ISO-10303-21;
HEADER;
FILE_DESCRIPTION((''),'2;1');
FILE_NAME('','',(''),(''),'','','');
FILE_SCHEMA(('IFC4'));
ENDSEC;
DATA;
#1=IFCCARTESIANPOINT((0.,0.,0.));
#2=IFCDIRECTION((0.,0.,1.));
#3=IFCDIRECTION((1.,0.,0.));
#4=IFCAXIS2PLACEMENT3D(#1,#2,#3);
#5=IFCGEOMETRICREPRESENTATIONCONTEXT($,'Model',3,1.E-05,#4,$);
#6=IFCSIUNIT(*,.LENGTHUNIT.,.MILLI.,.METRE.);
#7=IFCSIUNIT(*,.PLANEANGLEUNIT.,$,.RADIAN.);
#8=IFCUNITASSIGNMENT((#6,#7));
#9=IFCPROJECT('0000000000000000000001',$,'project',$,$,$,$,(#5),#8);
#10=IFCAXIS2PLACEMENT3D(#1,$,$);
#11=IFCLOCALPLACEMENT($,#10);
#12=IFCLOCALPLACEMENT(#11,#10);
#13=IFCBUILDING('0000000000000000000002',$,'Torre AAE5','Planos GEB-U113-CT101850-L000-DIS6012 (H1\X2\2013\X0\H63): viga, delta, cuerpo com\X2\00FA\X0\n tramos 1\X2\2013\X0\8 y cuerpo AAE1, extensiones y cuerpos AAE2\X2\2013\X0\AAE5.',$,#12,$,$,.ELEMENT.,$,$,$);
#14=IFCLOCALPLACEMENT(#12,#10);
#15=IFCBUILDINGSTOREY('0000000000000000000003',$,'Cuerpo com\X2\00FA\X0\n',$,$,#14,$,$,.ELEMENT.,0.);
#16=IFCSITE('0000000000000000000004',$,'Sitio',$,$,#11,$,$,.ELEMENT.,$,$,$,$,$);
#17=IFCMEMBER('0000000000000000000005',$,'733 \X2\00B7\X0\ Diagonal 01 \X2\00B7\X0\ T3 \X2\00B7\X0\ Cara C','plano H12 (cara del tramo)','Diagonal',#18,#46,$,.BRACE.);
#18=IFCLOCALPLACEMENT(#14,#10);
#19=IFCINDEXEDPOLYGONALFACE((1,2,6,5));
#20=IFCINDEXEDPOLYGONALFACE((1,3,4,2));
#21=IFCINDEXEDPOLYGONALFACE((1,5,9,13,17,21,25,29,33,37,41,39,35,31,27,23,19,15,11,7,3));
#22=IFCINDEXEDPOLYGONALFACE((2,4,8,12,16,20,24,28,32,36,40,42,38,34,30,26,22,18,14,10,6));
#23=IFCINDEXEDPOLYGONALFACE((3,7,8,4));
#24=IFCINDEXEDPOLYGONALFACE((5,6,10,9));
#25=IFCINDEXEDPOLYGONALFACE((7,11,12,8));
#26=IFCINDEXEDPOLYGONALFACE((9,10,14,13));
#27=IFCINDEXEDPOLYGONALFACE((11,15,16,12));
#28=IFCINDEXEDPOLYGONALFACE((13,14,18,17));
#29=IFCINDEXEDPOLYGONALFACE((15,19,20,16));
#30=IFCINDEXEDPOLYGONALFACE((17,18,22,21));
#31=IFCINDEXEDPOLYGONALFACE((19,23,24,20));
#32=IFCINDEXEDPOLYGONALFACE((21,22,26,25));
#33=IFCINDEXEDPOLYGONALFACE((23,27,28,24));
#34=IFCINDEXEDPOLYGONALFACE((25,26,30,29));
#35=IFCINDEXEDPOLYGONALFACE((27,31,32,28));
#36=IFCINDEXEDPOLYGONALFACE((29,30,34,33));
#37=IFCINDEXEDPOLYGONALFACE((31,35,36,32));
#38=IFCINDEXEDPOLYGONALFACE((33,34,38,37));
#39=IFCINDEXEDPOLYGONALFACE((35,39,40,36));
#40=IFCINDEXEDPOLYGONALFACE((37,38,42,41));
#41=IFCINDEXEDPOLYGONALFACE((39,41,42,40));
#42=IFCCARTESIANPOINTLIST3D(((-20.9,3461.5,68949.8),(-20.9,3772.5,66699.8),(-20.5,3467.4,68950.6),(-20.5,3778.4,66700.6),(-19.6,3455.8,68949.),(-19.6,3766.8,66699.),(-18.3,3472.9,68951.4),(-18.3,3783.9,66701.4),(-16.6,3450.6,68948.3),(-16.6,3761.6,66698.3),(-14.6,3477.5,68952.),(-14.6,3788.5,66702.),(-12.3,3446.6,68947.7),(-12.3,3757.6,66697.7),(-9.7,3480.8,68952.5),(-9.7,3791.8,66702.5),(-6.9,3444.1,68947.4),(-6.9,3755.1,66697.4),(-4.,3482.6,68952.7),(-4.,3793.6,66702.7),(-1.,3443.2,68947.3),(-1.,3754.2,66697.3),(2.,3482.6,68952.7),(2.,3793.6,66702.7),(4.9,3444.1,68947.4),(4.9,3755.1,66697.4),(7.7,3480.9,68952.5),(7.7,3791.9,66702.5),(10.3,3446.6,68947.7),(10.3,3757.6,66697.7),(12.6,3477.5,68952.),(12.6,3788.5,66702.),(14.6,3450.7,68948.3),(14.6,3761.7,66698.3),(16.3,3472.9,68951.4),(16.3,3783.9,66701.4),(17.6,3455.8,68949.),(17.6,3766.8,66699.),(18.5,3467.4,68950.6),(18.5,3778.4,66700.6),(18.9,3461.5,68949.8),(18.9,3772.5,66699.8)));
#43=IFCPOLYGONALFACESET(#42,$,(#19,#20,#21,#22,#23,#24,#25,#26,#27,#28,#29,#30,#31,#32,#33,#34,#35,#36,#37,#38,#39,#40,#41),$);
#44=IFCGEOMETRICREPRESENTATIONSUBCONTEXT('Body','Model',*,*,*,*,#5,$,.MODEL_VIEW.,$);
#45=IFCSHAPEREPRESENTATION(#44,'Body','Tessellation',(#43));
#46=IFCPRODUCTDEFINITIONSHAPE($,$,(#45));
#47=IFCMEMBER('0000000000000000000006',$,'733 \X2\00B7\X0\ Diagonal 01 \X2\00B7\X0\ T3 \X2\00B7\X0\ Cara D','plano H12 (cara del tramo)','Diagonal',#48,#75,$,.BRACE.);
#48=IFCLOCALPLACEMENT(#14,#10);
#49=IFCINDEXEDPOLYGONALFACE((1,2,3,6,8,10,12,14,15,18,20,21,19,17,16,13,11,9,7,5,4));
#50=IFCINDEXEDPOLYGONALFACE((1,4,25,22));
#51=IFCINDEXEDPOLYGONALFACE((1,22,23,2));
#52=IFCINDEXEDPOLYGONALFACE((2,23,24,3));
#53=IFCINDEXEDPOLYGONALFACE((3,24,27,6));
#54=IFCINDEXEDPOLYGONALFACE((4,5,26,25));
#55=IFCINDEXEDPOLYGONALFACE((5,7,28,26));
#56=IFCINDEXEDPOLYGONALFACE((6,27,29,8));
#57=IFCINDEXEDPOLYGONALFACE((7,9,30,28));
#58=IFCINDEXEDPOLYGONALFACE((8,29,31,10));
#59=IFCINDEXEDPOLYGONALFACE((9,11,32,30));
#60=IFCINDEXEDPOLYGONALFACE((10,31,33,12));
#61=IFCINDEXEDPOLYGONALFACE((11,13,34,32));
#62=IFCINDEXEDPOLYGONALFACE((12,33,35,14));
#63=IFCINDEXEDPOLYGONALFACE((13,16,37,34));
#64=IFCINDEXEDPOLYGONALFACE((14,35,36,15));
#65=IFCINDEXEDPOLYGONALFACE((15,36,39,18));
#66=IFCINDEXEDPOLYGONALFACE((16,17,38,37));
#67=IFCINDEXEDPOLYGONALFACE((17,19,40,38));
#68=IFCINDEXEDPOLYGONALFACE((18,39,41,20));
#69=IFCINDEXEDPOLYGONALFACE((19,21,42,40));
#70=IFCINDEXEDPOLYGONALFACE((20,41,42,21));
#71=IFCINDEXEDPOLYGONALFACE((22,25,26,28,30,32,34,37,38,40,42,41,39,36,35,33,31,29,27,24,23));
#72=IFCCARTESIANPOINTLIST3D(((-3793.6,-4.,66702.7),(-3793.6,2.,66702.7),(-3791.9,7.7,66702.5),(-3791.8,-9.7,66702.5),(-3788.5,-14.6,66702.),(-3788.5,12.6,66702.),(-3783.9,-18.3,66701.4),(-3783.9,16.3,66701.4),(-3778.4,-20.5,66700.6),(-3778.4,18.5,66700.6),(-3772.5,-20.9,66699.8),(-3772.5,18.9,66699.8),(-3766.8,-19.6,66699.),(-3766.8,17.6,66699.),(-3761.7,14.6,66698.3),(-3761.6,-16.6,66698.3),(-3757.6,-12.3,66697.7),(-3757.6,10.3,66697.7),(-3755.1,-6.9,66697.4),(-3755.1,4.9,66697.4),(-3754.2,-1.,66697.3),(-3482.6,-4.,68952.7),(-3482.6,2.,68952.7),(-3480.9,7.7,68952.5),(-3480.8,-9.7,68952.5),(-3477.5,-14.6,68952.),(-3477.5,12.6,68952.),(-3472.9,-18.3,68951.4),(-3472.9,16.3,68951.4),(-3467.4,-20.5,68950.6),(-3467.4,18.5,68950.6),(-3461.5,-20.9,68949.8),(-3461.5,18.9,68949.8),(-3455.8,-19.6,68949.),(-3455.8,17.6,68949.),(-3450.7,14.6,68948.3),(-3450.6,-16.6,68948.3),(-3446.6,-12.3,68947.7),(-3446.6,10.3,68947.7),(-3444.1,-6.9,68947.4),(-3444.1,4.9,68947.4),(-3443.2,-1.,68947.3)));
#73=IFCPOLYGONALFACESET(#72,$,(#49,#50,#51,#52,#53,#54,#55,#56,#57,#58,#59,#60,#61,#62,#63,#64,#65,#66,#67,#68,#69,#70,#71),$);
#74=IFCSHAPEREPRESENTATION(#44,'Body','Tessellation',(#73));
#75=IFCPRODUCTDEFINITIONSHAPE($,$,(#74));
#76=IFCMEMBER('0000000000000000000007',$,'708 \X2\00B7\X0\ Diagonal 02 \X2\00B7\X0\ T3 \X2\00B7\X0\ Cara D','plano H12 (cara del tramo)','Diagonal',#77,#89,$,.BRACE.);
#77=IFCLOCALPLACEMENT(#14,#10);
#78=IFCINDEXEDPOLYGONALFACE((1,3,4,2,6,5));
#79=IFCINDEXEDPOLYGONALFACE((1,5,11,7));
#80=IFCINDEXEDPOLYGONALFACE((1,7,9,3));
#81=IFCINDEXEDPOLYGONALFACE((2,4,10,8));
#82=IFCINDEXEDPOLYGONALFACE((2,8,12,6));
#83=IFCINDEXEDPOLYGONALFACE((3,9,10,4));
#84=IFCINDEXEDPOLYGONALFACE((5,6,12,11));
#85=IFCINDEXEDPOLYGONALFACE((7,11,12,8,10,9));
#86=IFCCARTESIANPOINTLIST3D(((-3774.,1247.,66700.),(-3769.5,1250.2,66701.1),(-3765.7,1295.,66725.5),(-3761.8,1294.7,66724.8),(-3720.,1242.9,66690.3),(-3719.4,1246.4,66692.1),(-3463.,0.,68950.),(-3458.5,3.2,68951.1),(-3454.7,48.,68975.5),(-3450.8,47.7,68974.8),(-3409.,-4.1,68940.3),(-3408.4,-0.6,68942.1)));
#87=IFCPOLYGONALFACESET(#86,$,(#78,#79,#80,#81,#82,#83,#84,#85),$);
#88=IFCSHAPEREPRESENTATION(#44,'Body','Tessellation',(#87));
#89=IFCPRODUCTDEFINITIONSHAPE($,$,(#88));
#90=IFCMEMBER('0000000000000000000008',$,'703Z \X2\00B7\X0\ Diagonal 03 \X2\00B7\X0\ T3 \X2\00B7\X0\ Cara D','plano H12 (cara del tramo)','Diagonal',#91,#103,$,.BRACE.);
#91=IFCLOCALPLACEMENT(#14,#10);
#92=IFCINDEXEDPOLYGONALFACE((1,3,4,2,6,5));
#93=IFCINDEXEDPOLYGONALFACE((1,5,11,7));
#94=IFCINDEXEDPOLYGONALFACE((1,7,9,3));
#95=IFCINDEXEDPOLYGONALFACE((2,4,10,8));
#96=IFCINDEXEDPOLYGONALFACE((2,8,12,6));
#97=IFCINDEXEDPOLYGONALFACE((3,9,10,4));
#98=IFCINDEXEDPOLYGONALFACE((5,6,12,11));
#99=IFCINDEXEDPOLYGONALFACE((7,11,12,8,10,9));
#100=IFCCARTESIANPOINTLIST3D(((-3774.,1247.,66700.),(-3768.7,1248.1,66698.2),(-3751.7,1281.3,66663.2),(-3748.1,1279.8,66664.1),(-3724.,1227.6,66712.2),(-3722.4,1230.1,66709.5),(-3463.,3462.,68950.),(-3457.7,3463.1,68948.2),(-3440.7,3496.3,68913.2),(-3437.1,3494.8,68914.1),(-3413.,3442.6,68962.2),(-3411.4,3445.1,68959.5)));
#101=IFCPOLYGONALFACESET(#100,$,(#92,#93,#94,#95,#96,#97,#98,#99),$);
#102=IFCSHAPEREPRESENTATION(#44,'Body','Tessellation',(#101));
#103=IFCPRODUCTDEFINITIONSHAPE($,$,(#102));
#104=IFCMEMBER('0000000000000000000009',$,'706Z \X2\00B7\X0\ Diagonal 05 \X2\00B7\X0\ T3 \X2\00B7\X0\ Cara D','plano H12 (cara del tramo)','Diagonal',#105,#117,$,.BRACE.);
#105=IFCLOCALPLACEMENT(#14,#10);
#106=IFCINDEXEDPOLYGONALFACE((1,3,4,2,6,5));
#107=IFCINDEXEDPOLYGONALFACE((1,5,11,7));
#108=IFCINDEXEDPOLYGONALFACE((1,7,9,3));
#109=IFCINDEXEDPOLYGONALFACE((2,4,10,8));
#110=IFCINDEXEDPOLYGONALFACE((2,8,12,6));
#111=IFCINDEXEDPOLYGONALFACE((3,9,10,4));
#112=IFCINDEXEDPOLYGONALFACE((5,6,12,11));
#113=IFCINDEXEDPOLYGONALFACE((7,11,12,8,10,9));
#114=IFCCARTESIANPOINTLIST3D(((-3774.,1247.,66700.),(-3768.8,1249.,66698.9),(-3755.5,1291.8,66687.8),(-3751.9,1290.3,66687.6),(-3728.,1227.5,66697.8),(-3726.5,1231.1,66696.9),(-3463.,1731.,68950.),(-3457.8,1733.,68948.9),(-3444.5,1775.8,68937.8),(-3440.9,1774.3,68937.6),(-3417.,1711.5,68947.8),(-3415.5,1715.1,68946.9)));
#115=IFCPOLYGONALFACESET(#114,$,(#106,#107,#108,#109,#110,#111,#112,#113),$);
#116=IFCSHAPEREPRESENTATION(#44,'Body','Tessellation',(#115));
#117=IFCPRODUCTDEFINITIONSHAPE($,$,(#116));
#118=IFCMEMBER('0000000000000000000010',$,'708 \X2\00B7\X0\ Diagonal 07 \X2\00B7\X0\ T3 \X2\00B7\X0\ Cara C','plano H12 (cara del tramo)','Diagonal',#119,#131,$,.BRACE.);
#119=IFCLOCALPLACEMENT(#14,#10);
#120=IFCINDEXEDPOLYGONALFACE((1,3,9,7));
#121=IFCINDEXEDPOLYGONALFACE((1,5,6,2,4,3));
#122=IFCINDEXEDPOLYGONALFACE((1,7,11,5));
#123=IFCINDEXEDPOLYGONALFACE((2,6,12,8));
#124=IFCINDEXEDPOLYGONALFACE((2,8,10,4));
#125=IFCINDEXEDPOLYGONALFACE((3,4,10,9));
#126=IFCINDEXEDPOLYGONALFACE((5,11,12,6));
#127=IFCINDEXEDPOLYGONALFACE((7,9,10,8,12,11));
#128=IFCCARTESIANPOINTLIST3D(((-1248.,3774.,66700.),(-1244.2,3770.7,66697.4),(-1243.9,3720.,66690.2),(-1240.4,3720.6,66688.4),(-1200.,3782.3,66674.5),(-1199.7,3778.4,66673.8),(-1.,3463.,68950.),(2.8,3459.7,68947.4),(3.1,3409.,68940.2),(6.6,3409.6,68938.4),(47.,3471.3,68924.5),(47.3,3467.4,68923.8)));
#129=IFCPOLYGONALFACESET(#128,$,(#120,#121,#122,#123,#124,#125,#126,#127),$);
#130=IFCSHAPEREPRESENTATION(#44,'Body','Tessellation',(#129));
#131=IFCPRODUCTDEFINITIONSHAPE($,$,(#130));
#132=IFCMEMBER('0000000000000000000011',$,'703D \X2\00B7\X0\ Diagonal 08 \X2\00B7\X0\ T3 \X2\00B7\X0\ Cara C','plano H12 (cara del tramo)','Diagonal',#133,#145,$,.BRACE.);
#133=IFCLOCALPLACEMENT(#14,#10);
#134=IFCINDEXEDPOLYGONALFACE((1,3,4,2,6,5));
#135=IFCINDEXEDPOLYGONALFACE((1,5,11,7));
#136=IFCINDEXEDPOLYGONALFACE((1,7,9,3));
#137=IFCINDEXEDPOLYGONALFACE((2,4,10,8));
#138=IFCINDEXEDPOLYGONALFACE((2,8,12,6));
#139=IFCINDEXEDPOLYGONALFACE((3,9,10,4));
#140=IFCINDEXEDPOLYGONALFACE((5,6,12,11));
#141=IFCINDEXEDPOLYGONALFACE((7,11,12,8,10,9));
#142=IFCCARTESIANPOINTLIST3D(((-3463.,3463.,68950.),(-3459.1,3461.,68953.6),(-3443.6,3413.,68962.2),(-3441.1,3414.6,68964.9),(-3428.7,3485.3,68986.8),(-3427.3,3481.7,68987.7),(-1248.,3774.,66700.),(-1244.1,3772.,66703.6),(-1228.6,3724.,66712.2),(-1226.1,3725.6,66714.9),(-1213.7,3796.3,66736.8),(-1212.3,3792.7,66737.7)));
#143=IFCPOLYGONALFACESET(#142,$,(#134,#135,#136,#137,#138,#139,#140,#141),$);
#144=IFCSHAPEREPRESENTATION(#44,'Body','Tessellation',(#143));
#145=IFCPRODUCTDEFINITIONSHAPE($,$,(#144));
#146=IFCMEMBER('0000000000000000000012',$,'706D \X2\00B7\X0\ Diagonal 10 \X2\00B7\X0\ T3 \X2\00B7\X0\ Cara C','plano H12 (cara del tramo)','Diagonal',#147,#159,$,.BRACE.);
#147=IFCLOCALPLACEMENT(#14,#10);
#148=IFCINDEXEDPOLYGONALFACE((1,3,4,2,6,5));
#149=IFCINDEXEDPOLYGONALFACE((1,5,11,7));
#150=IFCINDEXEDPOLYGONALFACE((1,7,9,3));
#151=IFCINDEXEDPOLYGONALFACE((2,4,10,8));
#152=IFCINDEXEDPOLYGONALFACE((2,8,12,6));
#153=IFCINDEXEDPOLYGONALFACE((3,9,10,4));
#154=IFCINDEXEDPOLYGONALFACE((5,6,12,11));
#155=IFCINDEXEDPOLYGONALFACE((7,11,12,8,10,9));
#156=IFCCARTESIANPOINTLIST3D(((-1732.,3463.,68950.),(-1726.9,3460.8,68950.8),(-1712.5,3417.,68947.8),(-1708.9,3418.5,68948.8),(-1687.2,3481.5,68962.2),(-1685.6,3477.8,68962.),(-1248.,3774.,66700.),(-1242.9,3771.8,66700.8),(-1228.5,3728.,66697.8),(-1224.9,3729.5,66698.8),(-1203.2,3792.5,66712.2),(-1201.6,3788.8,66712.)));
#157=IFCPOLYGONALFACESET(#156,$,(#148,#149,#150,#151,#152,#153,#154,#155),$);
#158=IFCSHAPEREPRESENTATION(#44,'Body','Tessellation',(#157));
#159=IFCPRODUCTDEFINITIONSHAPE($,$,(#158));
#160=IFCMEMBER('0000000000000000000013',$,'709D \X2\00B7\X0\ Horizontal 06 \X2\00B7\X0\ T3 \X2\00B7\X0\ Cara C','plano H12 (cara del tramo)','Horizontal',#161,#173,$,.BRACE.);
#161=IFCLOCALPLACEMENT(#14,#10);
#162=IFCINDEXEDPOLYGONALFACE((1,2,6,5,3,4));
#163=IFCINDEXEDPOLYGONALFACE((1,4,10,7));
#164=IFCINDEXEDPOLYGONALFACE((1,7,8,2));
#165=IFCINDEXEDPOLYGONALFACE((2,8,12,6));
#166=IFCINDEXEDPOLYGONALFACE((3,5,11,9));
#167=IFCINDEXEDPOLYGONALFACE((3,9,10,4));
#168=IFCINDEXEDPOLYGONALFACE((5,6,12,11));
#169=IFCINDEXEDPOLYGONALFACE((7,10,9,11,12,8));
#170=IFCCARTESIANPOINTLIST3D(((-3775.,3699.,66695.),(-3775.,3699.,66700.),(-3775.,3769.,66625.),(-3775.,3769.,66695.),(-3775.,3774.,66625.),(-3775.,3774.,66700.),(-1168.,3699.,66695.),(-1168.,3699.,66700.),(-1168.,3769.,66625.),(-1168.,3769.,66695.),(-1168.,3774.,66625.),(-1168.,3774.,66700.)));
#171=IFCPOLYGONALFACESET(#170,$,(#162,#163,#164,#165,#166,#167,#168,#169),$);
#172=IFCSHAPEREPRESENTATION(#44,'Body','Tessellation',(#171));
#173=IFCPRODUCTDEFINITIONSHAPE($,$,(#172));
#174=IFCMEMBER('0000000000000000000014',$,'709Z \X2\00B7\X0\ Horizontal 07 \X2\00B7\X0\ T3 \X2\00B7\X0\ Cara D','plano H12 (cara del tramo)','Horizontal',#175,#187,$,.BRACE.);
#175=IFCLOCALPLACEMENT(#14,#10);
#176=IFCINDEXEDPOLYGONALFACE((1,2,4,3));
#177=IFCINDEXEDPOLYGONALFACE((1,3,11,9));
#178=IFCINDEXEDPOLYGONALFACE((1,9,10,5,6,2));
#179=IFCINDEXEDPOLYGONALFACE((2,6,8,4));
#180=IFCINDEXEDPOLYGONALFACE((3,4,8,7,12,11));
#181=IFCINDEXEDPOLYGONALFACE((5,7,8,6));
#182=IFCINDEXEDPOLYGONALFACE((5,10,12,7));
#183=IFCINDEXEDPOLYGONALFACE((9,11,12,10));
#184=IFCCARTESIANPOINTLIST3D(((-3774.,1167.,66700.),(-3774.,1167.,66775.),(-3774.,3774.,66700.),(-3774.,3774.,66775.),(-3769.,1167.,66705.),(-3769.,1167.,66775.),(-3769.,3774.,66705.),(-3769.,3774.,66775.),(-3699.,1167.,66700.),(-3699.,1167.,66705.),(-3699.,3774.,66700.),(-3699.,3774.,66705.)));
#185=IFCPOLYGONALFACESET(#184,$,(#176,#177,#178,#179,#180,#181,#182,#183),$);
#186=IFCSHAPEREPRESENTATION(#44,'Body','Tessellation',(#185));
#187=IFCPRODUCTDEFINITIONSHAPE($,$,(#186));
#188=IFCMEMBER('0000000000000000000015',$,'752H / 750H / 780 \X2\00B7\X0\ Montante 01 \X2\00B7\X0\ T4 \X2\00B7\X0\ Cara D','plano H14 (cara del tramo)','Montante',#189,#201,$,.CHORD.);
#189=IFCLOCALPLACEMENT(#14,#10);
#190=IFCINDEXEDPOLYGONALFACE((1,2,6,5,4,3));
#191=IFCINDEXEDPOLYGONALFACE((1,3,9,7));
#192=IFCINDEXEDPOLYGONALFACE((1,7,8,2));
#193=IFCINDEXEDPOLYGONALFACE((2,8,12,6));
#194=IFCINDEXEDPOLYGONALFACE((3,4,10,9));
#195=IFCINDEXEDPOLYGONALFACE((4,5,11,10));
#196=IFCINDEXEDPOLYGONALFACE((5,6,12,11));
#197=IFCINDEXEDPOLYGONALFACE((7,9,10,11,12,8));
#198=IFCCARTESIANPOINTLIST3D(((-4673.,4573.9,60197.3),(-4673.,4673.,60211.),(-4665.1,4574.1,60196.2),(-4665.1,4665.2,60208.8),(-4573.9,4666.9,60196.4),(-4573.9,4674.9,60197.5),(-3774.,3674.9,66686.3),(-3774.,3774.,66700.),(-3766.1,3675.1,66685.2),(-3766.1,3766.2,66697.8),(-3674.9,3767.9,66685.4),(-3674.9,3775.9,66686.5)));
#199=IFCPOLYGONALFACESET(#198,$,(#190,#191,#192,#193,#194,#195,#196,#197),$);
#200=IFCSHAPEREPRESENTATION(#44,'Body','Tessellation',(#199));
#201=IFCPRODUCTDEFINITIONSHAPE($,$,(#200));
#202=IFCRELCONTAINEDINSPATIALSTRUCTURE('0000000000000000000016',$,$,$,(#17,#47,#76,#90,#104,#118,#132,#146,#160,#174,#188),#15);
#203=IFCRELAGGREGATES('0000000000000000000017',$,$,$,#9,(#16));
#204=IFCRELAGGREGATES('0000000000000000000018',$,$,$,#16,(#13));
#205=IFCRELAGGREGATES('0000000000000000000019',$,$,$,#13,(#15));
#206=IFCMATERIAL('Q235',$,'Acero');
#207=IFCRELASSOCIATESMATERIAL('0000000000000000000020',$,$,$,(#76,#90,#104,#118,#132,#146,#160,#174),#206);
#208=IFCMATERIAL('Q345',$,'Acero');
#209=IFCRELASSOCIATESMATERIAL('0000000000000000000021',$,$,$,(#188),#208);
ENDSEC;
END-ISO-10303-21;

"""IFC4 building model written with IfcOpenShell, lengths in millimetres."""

from ifc_helpers import new_model, si_unit, frame, frame_2d, origin, origin_with_axes, place, context, subcontext, project, spatial, circle, l_section, extrude, material, element, save


model = new_model("IFC4")

# Units and contexts
model_context = context("Model", 3, precision=1e-05, world=origin_with_axes())
body_context = subcontext(model_context, "Body", "Model", "MODEL_VIEW")
ifc_project = project(units=[si_unit("LENGTHUNIT", "METRE", prefix="MILLI"), si_unit("PLANEANGLEUNIT", "RADIAN")], contexts=[model_context])

# Site, building, storey
site_placement = place(None, origin())
site = spatial("IfcSite", under=ifc_project, at=site_placement, Name="Sitio", CompositionType="ELEMENT")
building_placement = place(site_placement, origin())
building = spatial("IfcBuilding", under=site, at=building_placement, Name="Torre AAE5", Description="Planos GEB-U113-CT101850-L000-DIS6012 (H1–H63): viga, delta, cuerpo común tramos 1–8 y cuerpo AAE1, extensiones y cuerpos AAE2–AAE5.", CompositionType="ELEMENT")
storey_placement = place(building_placement, origin())
storey = spatial("IfcBuildingStorey", under=building, at=storey_placement, Name="Cuerpo común", CompositionType="ELEMENT", Elevation=0.0)

# Members
for number, where, z_axis, x_axis, name in (
    (1, (-1.0, 3774.0, 66700.0), (0.0, -0.13692, 0.990582), (0.000279, -0.990582, -0.13692), "733 · Diagonal 01 · T3 · Cara C"),
    (2, (-3774.0, -1.0, 66700.0), (0.13692, 0.0, 0.990582), (0.990582, 0.000279, -0.13692), "733 · Diagonal 01 · T3 · Cara D"),
):
    element("IfcMember", number, at=place(storey_placement, frame(where, z_axis=z_axis, x_axis=x_axis)), inside=storey, Name=name, Description="plano H12 (cara del tramo)", ObjectType="Diagonal", PredefinedType="BRACE", context=body_context, shape_type="SweptSolid", body=[
        extrude(circle(Radius=20.0), None, (0.0, 0.0, 1.0), 2271.4),
    ])
ifc_material_1 = material(Name="Q235", Category="Acero")
member_1_placement = place(storey_placement, frame((-3774.0, 1247.0, 66700.0), z_axis=(0.120022, -0.481247, 0.868329), x_axis=(0.981299, -0.075075, -0.177245)))
element("IfcMember", 3, at=member_1_placement, inside=storey, material=ifc_material_1, Name="708 · Diagonal 02 · T3 · Cara D", Description="plano H12 (cara del tramo)", ObjectType="Diagonal", PredefinedType="BRACE", context=body_context, shape_type="SweptSolid", body=[
    extrude(l_section(Depth=55.0, Width=55.0, Thickness=4.0, at=frame_2d((27.5, 27.5))), None, (0.0, 0.0, 1.0), 2591.2),
])
member_2_placement = place(storey_placement, frame((-3774.0, 1247.0, 66700.0), z_axis=(0.098027, 0.698164, 0.709196), x_axis=(0.908922, -0.35302, 0.221895)))
element("IfcMember", 4, at=member_2_placement, inside=storey, material=ifc_material_1, Name="703Z · Diagonal 03 · T3 · Cara D", Description="plano H12 (cara del tramo)", ObjectType="Diagonal", PredefinedType="BRACE", context=body_context, shape_type="SweptSolid", body=[
    extrude(l_section(Depth=55.0, Width=55.0, Thickness=4.0, at=frame_2d((27.5, 27.5))), None, (0.0, 0.0, 1.0), 3172.6),
])
member_3_placement = place(storey_placement, frame((-3774.0, 1247.0, 66700.0), z_axis=(0.133914, 0.208406, 0.968831), x_axis=(0.919714, -0.390206, -0.043187)))
element("IfcMember", 5, at=member_3_placement, inside=storey, material=ifc_material_1, Name="706Z · Diagonal 05 · T3 · Cara D", Description="plano H12 (cara del tramo)", ObjectType="Diagonal", PredefinedType="BRACE", context=body_context, shape_type="SweptSolid", body=[
    extrude(l_section(Depth=50.0, Width=50.0, Thickness=4.0, at=frame_2d((25.0, 25.0))), None, (0.0, 0.0, 1.0), 2322.4),
])
member_4_placement = place(storey_placement, frame((-1248.0, 3774.0, 66700.0), z_axis=(0.481247, -0.120022, 0.868329), x_axis=(0.075287, -0.981263, -0.177358)))
element("IfcMember", 6, at=member_4_placement, inside=storey, material=ifc_material_1, Name="708 · Diagonal 07 · T3 · Cara C", Description="plano H12 (cara del tramo)", ObjectType="Diagonal", PredefinedType="BRACE", context=body_context, shape_type="SweptSolid", body=[
    extrude(l_section(Depth=55.0, Width=55.0, Thickness=4.0, at=frame_2d((27.5, 27.5))), None, (0.0, 0.0, 1.0), 2591.2),
])
member_5_placement = place(storey_placement, frame((-1248.0, 3774.0, 66700.0), z_axis=(-0.698164, -0.098027, 0.709196), x_axis=(0.353114, -0.908861, 0.221997)))
element("IfcMember", 7, at=member_5_placement, inside=storey, material=ifc_material_1, Name="703D · Diagonal 08 · T3 · Cara C", Description="plano H12 (cara del tramo)", ObjectType="Diagonal", PredefinedType="BRACE", context=body_context, shape_type="SweptSolid", body=[
    extrude(l_section(Depth=55.0, Width=55.0, Thickness=4.0, at=frame_2d((27.5, 27.5))), None, (0.0, 0.0, 1.0), 3172.6),
])
member_6_placement = place(storey_placement, frame((-1248.0, 3774.0, 66700.0), z_axis=(-0.208406, -0.133914, 0.968831), x_axis=(0.390411, -0.91963, -0.043131)))
element("IfcMember", 8, at=member_6_placement, inside=storey, material=ifc_material_1, Name="706D · Diagonal 10 · T3 · Cara C", Description="plano H12 (cara del tramo)", ObjectType="Diagonal", PredefinedType="BRACE", context=body_context, shape_type="SweptSolid", body=[
    extrude(l_section(Depth=50.0, Width=50.0, Thickness=4.0, at=frame_2d((25.0, 25.0))), None, (0.0, 0.0, 1.0), 2322.4),
])
for number, where, z_axis, x_axis, name in (
    (9, (-3775.0, 3774.0, 66700.0), (1.0, 0.0, 0.0), (0.0, -1.0, 0.0), "709D · Horizontal 06 · T3 · Cara C"),
    (10, (-3774.0, 3774.0, 66700.0), (0.0, -1.0, 0.0), (1.0, 0.0, 0.0), "709Z · Horizontal 07 · T3 · Cara D"),
):
    element("IfcMember", number, at=place(storey_placement, frame(where, z_axis=z_axis, x_axis=x_axis)), inside=storey, material=ifc_material_1, Name=name, Description="plano H12 (cara del tramo)", ObjectType="Horizontal", PredefinedType="BRACE", context=body_context, shape_type="SweptSolid", body=[
        extrude(l_section(Depth=75.0, Width=75.0, Thickness=5.0, at=frame_2d((37.5, 37.5))), None, (0.0, 0.0, 1.0), 2607.0),
    ])
ifc_material_2 = material(Name="Q345", Category="Acero")
member_7_placement = place(storey_placement, frame((-3774.0, 3774.0, 66700.0), z_axis=(-0.135957, 0.135957, -0.981342), x_axis=(0.990715, 0.018658, -0.134671)))
element("IfcMember", 11, at=member_7_placement, inside=storey, material=ifc_material_2, Name="752H / 750H / 780 · Montante 01 · T4 · Cara D", Description="plano H14 (cara del tramo)", ObjectType="Montante", PredefinedType="CHORD", context=body_context, shape_type="SweptSolid", body=[
    extrude(l_section(Depth=100.0, Width=100.0, Thickness=8.0, at=frame_2d((50.0, 50.0))), None, (0.0, 0.0, 1.0), 6612.4),
])

save(model, "model.ifc")
